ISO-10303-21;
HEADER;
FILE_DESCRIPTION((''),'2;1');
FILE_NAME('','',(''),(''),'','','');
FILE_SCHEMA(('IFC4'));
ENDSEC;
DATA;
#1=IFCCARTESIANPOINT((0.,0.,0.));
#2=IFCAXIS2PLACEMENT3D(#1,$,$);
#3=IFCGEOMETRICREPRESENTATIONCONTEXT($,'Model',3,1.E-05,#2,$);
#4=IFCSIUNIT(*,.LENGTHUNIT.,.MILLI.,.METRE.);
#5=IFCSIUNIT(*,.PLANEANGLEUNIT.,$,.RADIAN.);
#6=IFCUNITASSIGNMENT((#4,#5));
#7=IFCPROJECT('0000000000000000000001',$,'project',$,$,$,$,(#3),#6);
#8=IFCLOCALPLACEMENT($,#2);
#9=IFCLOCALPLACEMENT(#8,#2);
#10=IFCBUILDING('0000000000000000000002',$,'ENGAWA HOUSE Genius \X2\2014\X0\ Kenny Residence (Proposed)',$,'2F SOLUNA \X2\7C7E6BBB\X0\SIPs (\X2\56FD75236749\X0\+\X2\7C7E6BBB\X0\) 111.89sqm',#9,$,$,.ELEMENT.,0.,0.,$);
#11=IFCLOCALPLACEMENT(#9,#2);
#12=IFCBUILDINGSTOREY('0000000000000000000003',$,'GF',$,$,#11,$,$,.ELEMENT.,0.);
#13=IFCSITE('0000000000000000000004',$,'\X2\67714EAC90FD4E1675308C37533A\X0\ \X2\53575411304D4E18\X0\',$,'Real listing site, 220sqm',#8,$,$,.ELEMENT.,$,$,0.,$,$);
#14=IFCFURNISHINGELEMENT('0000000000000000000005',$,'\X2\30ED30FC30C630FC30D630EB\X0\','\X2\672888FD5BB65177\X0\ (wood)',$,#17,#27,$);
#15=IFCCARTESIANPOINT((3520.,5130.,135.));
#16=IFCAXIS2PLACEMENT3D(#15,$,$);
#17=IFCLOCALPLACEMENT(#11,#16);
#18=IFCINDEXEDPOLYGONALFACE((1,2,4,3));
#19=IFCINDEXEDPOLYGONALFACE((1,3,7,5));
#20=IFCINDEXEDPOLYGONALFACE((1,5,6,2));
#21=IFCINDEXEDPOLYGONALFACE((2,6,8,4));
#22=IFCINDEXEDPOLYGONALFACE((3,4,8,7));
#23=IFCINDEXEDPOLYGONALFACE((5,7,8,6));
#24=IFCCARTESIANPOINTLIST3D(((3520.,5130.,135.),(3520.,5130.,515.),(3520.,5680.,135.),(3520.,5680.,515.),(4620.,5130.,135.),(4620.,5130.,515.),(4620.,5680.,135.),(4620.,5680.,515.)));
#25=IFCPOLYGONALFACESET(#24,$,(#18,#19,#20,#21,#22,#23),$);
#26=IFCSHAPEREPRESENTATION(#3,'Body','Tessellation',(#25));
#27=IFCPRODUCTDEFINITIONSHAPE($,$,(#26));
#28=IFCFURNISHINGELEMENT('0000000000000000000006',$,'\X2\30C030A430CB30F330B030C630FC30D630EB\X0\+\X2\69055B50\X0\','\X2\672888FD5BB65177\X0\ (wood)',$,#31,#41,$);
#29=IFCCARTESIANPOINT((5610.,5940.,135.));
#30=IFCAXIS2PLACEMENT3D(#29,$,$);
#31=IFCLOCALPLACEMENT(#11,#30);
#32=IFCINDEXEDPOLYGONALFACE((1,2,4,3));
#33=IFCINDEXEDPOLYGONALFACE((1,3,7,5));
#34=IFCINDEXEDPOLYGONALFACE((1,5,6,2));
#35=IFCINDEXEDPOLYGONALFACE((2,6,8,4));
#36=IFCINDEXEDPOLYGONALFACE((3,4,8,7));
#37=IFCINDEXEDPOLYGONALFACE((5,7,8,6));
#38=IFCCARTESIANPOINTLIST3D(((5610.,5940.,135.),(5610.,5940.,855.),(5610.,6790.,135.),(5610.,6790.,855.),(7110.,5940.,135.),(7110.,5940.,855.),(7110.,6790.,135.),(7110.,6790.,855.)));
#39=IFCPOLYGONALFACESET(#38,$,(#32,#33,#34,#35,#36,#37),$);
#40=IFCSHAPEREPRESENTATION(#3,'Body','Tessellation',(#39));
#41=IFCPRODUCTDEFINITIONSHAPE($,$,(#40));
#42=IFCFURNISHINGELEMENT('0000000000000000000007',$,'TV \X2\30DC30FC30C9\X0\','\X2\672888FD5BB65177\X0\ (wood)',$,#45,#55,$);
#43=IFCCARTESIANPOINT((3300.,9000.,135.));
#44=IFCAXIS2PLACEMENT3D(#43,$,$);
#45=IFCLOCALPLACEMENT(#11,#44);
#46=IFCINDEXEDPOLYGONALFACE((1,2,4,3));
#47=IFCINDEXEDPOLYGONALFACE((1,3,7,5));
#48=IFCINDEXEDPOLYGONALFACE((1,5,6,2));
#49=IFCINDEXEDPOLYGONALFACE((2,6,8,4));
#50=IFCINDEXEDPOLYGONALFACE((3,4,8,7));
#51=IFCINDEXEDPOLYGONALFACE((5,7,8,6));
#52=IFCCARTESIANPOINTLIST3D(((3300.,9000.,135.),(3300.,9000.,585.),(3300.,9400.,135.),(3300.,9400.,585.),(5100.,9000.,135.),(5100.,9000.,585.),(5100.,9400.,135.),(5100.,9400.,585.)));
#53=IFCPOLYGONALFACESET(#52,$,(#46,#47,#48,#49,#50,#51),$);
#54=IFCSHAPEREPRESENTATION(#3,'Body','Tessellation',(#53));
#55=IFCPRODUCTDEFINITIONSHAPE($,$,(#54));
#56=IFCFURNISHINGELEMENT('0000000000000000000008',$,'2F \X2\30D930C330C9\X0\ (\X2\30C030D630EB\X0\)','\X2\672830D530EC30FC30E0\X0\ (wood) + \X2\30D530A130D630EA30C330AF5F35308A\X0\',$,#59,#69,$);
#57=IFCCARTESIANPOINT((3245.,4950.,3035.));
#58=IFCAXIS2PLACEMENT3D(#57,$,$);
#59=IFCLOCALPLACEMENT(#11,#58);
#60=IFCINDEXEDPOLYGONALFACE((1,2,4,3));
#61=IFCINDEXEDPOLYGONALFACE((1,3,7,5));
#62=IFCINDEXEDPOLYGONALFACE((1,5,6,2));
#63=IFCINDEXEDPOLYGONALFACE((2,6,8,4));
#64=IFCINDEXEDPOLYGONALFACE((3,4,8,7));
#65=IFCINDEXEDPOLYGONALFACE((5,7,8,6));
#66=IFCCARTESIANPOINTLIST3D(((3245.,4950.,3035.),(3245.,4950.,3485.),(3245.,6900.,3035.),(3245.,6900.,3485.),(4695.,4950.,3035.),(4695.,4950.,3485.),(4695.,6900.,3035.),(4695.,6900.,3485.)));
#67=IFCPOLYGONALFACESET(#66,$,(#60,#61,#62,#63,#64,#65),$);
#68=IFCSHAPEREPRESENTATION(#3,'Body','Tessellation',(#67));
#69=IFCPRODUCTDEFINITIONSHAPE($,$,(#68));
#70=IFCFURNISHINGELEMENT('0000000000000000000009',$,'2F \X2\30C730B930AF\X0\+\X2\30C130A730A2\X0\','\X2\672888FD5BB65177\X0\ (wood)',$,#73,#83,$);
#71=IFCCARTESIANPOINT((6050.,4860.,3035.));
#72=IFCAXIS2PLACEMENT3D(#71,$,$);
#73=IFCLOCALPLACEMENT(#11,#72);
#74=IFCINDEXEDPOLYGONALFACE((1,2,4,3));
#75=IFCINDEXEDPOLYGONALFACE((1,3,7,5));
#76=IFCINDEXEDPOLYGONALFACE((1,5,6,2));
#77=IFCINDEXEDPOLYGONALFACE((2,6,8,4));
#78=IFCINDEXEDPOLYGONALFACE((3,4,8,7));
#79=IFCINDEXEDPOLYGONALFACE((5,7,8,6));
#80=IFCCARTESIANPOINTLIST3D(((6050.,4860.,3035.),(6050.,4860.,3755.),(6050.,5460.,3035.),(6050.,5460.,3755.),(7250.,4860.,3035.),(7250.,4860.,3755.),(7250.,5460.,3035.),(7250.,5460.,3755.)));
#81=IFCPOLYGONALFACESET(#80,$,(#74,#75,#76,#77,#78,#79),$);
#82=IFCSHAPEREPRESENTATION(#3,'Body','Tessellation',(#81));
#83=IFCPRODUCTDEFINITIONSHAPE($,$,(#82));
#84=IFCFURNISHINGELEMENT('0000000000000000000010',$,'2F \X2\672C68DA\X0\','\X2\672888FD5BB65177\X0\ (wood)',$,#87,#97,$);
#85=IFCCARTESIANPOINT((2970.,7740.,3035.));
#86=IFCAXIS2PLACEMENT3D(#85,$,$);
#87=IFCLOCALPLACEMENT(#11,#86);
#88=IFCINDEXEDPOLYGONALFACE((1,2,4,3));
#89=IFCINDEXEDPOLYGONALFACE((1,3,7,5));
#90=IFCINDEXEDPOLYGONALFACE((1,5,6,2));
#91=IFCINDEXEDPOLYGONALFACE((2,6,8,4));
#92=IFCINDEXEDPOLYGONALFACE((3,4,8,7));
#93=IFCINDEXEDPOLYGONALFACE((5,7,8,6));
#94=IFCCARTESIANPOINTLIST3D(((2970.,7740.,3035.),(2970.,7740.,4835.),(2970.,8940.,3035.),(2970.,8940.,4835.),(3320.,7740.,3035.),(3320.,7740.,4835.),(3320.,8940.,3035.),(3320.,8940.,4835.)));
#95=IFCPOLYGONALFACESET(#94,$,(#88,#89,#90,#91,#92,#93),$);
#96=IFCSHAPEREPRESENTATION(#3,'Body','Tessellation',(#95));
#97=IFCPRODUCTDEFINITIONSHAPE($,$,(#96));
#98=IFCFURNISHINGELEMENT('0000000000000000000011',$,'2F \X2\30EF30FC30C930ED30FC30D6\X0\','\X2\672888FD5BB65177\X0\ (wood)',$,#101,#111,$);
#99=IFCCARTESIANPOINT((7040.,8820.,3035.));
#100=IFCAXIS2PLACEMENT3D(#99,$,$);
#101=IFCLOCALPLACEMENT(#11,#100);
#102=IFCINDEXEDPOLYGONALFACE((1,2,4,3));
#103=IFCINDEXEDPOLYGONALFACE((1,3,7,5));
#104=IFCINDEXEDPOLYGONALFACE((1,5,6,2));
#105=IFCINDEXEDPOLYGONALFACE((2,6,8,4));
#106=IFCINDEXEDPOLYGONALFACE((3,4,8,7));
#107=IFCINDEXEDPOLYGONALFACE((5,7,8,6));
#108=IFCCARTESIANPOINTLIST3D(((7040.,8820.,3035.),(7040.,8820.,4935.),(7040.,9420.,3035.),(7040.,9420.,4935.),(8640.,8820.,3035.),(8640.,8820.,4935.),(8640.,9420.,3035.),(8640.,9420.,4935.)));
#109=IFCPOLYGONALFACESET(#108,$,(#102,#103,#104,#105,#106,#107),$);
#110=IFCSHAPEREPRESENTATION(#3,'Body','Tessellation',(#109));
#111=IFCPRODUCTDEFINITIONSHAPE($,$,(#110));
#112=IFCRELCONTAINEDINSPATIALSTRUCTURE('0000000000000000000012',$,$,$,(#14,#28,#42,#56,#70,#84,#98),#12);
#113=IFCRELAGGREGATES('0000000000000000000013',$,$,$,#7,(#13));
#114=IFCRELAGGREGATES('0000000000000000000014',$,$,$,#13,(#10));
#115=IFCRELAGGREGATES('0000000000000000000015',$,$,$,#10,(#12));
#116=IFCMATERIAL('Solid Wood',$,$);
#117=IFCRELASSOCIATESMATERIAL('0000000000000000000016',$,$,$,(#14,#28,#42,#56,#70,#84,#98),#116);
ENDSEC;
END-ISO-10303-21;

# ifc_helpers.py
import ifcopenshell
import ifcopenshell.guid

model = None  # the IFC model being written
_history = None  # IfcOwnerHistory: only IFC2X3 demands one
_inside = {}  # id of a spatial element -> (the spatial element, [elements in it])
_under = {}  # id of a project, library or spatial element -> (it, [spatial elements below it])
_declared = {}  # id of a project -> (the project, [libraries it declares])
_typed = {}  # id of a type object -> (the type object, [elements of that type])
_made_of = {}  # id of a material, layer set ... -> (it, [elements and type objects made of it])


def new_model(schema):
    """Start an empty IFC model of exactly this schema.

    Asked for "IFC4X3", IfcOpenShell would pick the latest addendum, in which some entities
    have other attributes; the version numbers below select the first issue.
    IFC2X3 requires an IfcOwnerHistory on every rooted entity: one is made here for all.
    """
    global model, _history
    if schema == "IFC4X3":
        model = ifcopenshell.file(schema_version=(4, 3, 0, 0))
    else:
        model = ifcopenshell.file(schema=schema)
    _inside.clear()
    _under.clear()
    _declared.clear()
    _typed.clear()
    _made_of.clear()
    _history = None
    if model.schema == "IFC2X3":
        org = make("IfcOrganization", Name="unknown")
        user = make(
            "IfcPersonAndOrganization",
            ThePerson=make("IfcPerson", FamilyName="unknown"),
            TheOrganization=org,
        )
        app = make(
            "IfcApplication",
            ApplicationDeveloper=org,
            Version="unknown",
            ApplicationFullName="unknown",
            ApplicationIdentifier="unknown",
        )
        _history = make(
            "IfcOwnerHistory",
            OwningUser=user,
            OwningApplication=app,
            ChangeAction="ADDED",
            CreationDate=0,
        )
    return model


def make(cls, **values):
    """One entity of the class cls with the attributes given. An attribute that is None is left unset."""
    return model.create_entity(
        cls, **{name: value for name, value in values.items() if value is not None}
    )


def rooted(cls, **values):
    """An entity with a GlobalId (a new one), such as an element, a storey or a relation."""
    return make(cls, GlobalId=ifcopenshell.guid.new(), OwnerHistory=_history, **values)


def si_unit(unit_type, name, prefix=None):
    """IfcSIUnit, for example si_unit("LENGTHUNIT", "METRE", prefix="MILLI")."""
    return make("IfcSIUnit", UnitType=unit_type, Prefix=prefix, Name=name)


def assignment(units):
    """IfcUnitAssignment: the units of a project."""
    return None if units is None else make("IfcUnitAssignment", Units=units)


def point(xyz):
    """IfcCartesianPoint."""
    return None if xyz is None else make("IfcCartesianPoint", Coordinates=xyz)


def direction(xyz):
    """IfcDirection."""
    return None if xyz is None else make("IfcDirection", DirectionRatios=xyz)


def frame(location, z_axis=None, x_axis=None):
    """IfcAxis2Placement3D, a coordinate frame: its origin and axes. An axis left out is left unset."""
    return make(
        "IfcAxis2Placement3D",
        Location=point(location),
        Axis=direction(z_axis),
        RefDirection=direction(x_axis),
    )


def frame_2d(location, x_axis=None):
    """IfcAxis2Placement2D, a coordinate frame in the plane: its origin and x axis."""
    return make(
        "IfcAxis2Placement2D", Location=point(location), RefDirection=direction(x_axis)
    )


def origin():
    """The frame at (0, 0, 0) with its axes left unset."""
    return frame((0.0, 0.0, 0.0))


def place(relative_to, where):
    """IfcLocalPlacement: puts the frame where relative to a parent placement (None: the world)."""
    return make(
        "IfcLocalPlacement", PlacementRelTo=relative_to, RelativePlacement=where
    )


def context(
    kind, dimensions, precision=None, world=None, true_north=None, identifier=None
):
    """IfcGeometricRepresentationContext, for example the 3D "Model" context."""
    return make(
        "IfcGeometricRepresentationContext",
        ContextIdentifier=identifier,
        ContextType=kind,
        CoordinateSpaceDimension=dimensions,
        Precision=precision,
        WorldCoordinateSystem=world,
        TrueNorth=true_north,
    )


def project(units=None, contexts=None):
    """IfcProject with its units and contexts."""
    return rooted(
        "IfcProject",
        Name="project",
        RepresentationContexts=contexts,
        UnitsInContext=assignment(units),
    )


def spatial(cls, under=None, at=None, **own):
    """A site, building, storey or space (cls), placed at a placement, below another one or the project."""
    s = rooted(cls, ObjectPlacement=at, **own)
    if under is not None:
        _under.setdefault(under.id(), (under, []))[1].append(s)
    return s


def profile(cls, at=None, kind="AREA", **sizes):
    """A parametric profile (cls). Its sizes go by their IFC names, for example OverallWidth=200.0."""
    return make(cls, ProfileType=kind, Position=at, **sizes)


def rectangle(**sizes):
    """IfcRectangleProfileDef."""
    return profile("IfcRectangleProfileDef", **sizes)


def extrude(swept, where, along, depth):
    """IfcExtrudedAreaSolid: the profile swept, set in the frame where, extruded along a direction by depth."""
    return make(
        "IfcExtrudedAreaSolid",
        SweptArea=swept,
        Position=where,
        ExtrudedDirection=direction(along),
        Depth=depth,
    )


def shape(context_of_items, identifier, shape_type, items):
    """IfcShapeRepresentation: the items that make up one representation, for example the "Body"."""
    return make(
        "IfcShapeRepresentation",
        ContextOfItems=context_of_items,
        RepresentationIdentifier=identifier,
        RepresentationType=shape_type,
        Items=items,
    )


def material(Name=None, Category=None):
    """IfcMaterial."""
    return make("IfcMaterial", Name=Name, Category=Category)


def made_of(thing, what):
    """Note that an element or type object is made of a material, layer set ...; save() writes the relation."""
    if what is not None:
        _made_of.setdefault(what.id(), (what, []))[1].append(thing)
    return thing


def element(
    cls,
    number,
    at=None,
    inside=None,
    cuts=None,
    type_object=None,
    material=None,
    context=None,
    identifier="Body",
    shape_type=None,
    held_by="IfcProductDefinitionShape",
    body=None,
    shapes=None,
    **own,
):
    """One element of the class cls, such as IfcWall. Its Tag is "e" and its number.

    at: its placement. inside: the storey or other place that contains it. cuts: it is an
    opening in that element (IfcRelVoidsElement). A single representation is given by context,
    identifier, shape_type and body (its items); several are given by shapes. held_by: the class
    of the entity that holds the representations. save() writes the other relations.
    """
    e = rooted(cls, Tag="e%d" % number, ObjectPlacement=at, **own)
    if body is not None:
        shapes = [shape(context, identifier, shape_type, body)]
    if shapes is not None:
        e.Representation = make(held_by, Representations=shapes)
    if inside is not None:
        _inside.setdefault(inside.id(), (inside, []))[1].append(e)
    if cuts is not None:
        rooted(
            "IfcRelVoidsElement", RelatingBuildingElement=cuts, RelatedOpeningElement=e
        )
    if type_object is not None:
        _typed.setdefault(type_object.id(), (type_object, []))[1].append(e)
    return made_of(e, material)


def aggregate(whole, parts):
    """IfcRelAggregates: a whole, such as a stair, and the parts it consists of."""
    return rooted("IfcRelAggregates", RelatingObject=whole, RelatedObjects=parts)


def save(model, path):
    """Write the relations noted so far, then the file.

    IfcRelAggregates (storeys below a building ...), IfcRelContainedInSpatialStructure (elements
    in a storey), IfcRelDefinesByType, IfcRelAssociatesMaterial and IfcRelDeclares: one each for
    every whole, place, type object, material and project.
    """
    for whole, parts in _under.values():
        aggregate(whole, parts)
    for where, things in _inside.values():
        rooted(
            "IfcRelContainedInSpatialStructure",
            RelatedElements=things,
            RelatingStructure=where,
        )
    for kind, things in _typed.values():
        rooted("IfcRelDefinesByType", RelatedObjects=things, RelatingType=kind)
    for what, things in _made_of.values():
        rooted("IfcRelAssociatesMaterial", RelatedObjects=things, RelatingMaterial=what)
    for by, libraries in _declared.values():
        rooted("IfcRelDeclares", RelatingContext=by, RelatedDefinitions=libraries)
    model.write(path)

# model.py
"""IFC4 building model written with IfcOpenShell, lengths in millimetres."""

from ifc_helpers import new_model, si_unit, frame, frame_2d, origin, place, context, project, spatial, rectangle, extrude, material, element, save


model = new_model("IFC4")

# Units and contexts
model_context = context("Model", 3, precision=1e-05, world=origin())
ifc_project = project(units=[si_unit("LENGTHUNIT", "METRE", prefix="MILLI"), si_unit("PLANEANGLEUNIT", "RADIAN")], contexts=[model_context])

# Site, building, storey
site_placement = place(None, origin())
site = spatial("IfcSite", under=ifc_project, at=site_placement, Name="東京都世田谷区 南向き丘", ObjectType="Real listing site, 220sqm", CompositionType="ELEMENT", RefElevation=0.0)
building_placement = place(site_placement, origin())
building = spatial("IfcBuilding", under=site, at=building_placement, Name="ENGAWA HOUSE Genius — Kenny Residence (Proposed)", ObjectType="2F SOLUNA 籾殻SIPs (国産杉+籾殻) 111.89sqm", CompositionType="ELEMENT", ElevationOfRefHeight=0.0, ElevationOfTerrain=0.0)
storey_placement = place(building_placement, origin())
storey = spatial("IfcBuildingStorey", under=building, at=storey_placement, Name="GF", CompositionType="ELEMENT", Elevation=0.0)

# Shared definitions
ifc_material_1 = material(Name="Solid Wood")

# Furnishing elements
furnishing_1_placement = place(storey_placement, frame((3520.0, 5130.0, 135.0)))
element("IfcFurnishingElement", 1, at=furnishing_1_placement, inside=storey, material=ifc_material_1, Name="ローテーブル", Description="木製家具 (wood)", context=model_context, shape_type="SweptSolid", body=[
    extrude(rectangle(XDim=1100.0, YDim=550.0, at=frame_2d((550.0, 275.0))), frame((3520.0, 5130.0, 135.0)), (0.0, 0.0, 1.0), 380.0),
])
furnishing_2_placement = place(storey_placement, frame((5610.0, 5940.0, 135.0)))
element("IfcFurnishingElement", 2, at=furnishing_2_placement, inside=storey, material=ifc_material_1, Name="ダイニングテーブル+椅子", Description="木製家具 (wood)", context=model_context, shape_type="SweptSolid", body=[
    extrude(rectangle(XDim=1500.0, YDim=850.0, at=frame_2d((750.0, 425.0))), frame((5610.0, 5940.0, 135.0)), (0.0, 0.0, 1.0), 720.0),
])
furnishing_3_placement = place(storey_placement, frame((3300.0, 9000.0, 135.0)))
element("IfcFurnishingElement", 3, at=furnishing_3_placement, inside=storey, material=ifc_material_1, Name="TV ボード", Description="木製家具 (wood)", context=model_context, shape_type="SweptSolid", body=[
    extrude(rectangle(XDim=1800.0, YDim=400.0, at=frame_2d((900.0, 200.0))), frame((3300.0, 9000.0, 135.0)), (0.0, 0.0, 1.0), 450.0),
])
furnishing_4_placement = place(storey_placement, frame((3245.0, 4950.0, 3035.0)))
element("IfcFurnishingElement", 4, at=furnishing_4_placement, inside=storey, material=ifc_material_1, Name="2F ベッド (ダブル)", Description="木フレーム (wood) + ファブリック張り", context=model_context, shape_type="SweptSolid", body=[
    extrude(rectangle(XDim=1450.0, YDim=1950.0, at=frame_2d((725.0, 975.0))), frame((3245.0, 4950.0, 3035.0)), (0.0, 0.0, 1.0), 450.0),
])
furnishing_5_placement = place(storey_placement, frame((6050.0, 4860.0, 3035.0)))
element("IfcFurnishingElement", 5, at=furnishing_5_placement, inside=storey, material=ifc_material_1, Name="2F デスク+チェア", Description="木製家具 (wood)", context=model_context, shape_type="SweptSolid", body=[
    extrude(rectangle(XDim=1200.0, YDim=600.0, at=frame_2d((600.0, 300.0))), frame((6050.0, 4860.0, 3035.0)), (0.0, 0.0, 1.0), 720.0),
])
furnishing_6_placement = place(storey_placement, frame((2970.0, 7740.0, 3035.0)))
element("IfcFurnishingElement", 6, at=furnishing_6_placement, inside=storey, material=ifc_material_1, Name="2F 本棚", Description="木製家具 (wood)", context=model_context, shape_type="SweptSolid", body=[
    extrude(rectangle(XDim=350.0, YDim=1200.0, at=frame_2d((175.0, 600.0))), frame((2970.0, 7740.0, 3035.0)), (0.0, 0.0, 1.0), 1800.0),
])
furnishing_7_placement = place(storey_placement, frame((7040.0, 8820.0, 3035.0)))
element("IfcFurnishingElement", 7, at=furnishing_7_placement, inside=storey, material=ifc_material_1, Name="2F ワードローブ", Description="木製家具 (wood)", context=model_context, shape_type="SweptSolid", body=[
    extrude(rectangle(XDim=1600.0, YDim=600.0, at=frame_2d((800.0, 300.0))), frame((7040.0, 8820.0, 3035.0)), (0.0, 0.0, 1.0), 1900.0),
])

save(model, "model.ifc")
